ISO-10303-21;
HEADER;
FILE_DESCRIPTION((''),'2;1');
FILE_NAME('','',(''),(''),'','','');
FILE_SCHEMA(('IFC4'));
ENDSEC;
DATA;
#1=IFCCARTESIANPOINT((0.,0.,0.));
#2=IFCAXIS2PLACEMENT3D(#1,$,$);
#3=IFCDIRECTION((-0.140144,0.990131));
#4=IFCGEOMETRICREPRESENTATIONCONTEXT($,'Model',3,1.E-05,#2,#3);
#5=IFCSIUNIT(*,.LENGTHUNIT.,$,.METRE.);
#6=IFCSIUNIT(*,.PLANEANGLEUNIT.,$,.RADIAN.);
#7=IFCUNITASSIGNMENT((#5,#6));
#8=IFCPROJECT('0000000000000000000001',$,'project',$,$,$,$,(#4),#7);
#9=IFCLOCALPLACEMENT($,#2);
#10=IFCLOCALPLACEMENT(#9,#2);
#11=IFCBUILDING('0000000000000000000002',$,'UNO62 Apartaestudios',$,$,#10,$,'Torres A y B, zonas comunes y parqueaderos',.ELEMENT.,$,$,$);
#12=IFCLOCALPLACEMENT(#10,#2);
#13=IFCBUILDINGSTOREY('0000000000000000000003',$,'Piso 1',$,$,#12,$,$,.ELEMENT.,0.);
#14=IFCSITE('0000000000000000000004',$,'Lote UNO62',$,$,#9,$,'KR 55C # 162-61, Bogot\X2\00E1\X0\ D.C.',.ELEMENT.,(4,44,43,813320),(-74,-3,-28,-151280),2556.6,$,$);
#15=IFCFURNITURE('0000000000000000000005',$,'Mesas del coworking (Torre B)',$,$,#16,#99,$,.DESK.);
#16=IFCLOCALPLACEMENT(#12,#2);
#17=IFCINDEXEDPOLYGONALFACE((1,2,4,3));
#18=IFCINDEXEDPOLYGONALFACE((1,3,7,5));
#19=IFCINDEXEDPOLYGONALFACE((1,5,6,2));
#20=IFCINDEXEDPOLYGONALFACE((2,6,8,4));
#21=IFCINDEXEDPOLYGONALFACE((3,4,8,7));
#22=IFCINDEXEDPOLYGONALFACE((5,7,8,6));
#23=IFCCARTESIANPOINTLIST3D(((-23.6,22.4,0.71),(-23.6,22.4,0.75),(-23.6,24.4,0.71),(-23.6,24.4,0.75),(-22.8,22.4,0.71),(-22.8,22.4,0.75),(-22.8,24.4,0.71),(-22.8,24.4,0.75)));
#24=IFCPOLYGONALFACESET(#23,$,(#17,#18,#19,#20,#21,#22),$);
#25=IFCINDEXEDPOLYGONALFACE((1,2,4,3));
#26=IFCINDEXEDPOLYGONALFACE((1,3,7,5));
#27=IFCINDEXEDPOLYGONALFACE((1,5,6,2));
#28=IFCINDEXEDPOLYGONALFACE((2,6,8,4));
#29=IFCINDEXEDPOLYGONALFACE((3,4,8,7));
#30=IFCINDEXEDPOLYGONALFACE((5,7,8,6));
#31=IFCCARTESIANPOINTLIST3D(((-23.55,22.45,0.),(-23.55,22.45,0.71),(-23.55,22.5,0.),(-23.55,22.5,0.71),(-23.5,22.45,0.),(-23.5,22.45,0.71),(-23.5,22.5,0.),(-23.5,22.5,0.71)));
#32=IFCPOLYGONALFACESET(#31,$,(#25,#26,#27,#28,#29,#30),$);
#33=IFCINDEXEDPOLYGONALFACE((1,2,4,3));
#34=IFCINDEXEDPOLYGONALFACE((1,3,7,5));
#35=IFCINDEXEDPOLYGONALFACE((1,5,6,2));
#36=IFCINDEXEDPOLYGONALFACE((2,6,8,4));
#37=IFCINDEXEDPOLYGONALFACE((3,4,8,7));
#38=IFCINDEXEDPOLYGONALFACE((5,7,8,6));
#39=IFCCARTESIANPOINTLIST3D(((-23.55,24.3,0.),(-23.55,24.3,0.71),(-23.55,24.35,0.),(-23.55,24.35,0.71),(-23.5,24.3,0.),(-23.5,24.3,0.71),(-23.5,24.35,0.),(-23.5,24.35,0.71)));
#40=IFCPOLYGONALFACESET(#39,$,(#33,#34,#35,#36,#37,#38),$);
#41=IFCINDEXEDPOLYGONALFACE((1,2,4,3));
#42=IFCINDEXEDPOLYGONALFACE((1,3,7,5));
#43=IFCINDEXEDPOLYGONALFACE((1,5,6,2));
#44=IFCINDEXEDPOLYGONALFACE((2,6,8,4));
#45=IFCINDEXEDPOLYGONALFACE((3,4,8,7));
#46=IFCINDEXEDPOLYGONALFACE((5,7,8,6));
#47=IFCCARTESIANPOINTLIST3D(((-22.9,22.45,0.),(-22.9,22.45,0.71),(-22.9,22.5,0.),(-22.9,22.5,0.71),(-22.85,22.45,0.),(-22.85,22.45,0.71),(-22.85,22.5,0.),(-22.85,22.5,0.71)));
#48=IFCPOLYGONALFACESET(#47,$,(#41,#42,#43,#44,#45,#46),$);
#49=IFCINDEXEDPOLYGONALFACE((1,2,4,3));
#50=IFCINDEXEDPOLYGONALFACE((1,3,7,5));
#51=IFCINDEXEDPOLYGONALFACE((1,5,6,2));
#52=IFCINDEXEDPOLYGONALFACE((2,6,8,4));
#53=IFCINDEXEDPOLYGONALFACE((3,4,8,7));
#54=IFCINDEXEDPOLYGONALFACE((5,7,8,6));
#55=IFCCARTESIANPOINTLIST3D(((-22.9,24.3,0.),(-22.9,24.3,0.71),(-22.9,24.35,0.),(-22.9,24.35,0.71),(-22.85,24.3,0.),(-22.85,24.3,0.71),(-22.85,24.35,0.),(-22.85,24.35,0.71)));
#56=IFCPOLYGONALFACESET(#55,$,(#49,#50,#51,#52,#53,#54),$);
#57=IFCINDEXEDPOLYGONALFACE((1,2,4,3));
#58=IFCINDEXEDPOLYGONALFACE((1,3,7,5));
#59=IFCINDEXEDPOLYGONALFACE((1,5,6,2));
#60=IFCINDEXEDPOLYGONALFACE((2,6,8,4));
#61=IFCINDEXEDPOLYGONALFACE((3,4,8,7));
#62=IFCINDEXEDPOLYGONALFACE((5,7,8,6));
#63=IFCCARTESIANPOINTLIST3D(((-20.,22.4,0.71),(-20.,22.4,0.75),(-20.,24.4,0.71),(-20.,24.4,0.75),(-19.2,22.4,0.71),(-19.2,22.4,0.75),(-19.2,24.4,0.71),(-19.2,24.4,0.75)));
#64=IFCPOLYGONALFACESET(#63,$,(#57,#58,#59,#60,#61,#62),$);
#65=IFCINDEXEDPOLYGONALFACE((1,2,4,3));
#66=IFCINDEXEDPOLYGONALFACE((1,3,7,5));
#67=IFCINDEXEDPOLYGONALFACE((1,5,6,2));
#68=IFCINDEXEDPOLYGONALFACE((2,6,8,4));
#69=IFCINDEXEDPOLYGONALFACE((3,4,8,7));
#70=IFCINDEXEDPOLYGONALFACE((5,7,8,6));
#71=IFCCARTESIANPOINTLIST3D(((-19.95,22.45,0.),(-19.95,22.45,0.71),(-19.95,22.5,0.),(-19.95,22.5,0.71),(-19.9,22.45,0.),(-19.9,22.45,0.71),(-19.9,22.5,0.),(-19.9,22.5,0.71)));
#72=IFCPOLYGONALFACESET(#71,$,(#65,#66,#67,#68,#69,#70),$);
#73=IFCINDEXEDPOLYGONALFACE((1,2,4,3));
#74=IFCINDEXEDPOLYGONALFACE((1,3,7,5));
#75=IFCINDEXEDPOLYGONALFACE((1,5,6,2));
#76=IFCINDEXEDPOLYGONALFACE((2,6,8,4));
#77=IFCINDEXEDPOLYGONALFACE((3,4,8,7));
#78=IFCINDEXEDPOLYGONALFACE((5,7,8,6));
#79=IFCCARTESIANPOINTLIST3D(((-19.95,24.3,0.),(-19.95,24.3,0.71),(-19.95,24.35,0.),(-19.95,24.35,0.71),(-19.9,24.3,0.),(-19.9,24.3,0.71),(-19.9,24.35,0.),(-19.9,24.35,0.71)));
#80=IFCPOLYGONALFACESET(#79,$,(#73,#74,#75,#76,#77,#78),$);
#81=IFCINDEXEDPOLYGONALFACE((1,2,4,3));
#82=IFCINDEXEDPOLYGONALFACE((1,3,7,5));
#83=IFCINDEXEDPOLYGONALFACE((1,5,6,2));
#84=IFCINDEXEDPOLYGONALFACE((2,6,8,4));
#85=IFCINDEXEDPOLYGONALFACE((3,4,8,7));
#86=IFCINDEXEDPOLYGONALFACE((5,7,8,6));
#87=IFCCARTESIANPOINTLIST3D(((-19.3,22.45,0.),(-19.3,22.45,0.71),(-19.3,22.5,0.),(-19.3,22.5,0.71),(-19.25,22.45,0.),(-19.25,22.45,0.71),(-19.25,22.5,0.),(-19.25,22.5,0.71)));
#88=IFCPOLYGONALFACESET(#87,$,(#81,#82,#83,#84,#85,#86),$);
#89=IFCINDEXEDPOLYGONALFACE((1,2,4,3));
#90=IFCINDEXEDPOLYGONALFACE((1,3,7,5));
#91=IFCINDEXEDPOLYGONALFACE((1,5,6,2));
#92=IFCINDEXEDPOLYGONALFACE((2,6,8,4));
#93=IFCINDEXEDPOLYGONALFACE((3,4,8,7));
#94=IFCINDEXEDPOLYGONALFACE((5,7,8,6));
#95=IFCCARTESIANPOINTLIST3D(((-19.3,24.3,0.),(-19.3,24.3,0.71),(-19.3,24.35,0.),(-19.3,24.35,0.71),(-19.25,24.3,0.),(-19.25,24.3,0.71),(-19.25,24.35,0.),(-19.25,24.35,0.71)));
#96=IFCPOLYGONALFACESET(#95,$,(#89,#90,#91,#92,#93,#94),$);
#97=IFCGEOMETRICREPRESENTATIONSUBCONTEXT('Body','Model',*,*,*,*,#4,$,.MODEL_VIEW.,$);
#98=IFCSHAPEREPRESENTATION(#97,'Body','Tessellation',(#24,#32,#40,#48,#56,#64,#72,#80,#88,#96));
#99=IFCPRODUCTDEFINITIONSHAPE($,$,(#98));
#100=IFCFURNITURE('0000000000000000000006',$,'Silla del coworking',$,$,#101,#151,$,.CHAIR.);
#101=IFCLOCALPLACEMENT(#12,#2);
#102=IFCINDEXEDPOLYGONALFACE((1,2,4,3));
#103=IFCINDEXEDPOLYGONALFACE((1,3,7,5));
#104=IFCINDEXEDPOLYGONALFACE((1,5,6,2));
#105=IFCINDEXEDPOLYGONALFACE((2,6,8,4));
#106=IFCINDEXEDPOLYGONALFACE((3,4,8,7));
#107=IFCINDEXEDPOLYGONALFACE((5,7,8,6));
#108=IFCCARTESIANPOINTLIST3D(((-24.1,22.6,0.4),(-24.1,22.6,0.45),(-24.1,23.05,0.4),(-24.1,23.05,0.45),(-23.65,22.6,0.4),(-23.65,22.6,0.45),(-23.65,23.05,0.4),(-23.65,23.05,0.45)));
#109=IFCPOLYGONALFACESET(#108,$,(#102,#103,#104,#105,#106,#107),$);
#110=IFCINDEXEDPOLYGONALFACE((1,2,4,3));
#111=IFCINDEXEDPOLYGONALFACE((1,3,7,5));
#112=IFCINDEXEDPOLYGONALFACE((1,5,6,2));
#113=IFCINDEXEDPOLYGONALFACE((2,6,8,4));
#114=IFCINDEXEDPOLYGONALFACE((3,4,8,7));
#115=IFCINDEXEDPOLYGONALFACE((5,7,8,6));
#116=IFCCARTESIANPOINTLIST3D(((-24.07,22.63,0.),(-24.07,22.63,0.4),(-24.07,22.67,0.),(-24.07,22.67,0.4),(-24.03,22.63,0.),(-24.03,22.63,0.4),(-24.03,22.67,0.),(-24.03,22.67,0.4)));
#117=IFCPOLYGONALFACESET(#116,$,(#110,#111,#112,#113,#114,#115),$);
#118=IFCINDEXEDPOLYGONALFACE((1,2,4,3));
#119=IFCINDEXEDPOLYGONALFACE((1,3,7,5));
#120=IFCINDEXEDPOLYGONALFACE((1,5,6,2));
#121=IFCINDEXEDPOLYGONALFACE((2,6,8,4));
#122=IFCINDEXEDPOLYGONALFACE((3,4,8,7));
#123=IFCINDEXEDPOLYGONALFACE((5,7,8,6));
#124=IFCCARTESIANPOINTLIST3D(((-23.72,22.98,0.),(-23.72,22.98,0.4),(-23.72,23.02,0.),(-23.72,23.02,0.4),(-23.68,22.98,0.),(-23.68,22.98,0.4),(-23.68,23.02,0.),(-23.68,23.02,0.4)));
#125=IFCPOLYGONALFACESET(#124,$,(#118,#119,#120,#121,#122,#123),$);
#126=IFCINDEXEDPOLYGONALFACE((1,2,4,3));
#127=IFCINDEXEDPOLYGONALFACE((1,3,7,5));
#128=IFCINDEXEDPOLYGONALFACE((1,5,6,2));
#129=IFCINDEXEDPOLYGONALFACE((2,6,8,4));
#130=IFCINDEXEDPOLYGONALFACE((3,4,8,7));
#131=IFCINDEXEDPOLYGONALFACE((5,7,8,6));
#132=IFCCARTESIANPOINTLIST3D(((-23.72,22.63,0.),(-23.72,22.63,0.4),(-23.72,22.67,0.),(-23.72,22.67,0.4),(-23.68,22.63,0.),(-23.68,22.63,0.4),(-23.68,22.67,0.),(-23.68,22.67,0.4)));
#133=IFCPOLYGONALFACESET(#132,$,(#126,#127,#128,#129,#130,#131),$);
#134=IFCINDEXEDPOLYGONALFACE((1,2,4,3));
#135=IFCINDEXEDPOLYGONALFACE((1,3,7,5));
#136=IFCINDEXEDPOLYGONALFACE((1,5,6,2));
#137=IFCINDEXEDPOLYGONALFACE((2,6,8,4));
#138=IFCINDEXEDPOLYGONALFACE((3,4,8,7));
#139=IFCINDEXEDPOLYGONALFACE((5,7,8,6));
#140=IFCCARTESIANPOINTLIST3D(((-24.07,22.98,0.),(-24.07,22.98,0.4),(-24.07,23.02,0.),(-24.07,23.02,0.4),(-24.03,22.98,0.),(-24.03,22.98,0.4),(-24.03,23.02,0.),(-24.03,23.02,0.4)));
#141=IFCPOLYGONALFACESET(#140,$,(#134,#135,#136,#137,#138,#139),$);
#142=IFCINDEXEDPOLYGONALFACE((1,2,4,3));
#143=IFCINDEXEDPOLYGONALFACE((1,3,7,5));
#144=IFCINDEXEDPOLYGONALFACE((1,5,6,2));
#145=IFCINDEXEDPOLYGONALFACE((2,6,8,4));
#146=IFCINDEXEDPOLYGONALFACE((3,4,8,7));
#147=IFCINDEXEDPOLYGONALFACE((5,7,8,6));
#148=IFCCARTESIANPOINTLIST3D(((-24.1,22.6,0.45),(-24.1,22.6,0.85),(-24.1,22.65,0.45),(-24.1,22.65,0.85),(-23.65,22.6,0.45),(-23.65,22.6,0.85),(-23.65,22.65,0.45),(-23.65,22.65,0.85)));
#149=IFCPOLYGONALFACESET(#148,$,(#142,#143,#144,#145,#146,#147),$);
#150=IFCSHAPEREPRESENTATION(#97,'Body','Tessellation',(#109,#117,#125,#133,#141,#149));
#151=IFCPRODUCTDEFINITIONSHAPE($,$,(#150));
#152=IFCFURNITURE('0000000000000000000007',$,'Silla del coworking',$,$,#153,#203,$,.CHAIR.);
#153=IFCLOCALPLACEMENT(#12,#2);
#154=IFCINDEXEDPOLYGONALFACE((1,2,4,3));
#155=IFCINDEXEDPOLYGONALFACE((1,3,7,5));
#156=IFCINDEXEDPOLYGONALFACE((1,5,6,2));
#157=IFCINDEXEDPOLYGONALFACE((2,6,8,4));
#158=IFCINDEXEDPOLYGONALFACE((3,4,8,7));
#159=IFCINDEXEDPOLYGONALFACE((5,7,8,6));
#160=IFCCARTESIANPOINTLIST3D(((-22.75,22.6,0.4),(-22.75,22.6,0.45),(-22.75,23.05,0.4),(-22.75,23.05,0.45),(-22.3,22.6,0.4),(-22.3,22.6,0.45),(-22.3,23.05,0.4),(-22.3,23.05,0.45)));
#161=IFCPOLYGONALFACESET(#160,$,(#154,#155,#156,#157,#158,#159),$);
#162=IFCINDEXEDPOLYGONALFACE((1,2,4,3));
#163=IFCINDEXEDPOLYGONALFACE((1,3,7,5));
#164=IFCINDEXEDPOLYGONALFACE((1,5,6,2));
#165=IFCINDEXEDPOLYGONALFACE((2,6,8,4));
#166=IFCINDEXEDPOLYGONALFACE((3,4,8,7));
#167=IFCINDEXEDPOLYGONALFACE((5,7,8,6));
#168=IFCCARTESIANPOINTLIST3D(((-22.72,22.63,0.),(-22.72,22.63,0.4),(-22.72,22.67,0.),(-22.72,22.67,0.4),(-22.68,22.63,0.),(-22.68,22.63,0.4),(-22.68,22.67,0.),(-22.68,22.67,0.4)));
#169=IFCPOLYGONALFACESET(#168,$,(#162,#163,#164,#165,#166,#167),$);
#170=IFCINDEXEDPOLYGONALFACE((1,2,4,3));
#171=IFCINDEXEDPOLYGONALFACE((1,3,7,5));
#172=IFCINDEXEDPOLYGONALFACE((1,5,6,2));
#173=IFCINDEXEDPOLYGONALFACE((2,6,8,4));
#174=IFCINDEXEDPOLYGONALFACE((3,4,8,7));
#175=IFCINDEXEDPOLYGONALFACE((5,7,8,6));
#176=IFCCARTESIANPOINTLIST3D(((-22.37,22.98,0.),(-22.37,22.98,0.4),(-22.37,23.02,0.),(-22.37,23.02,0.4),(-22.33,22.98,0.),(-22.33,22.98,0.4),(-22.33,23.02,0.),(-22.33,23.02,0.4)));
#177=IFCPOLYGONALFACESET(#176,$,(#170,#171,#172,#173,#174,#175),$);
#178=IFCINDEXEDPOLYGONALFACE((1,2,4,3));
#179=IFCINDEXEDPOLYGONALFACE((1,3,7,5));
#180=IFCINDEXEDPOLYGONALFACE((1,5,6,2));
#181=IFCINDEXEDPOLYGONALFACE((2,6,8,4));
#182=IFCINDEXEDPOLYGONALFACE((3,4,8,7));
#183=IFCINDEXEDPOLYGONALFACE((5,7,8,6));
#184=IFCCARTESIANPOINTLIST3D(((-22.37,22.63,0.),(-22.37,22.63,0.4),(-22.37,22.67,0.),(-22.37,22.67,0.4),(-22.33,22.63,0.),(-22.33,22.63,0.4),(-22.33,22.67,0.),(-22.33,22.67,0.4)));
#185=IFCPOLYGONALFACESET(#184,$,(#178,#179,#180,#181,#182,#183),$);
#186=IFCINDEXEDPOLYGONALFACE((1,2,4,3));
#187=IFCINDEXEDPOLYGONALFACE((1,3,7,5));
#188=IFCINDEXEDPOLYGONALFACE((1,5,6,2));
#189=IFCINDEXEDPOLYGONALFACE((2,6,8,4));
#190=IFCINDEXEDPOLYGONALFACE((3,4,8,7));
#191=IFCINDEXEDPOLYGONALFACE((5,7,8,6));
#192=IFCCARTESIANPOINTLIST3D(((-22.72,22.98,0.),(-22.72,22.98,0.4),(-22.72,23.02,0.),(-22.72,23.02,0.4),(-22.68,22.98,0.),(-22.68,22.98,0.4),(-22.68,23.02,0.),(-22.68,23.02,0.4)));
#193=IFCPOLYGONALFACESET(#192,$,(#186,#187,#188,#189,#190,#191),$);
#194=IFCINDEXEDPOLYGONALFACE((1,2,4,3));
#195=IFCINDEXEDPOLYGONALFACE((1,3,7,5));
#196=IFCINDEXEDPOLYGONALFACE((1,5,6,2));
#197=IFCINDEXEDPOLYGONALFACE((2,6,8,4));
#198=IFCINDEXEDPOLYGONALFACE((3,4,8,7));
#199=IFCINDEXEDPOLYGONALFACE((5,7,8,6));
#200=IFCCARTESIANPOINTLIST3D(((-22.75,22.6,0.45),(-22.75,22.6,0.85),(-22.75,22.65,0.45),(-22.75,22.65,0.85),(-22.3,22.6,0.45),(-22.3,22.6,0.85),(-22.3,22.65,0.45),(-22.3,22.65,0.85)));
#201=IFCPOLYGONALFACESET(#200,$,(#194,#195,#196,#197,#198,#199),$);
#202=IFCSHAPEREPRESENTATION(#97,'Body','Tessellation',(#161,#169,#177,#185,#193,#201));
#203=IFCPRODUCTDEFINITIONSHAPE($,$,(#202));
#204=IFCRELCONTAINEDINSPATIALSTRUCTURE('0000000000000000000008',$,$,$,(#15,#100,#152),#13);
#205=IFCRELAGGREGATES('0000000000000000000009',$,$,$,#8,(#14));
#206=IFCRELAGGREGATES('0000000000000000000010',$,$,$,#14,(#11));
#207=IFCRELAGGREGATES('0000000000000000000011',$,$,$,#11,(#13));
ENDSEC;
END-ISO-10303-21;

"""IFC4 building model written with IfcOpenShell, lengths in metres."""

from ifc_helpers import new_model, si_unit, direction, frame, frame_2d, origin, place, context, subcontext, project, spatial, rectangle, extrude, element, save


model = new_model("IFC4")

# Units and contexts
model_context = context("Model", 3, precision=1e-05, world=origin(), true_north=direction((-0.140144, 0.990131)))
body_context = subcontext(model_context, "Body", "Model", "MODEL_VIEW")
ifc_project = project(units=[si_unit("LENGTHUNIT", "METRE"), si_unit("PLANEANGLEUNIT", "RADIAN")], contexts=[model_context])

# Site, building, storey
site_placement = place(None, origin())
site = spatial("IfcSite", under=ifc_project, at=site_placement, Name="Lote UNO62", LongName="KR 55C # 162-61, Bogotá D.C.", CompositionType="ELEMENT", RefLatitude=(4, 44, 43, 813320), RefLongitude=(-74, -3, -28, -151280), RefElevation=2556.6)
building_placement = place(site_placement, origin())
building = spatial("IfcBuilding", under=site, at=building_placement, Name="UNO62 Apartaestudios", LongName="Torres A y B, zonas comunes y parqueaderos", CompositionType="ELEMENT")
storey_placement = place(building_placement, origin())
storey = spatial("IfcBuildingStorey", under=building, at=storey_placement, Name="Piso 1", CompositionType="ELEMENT", Elevation=0.0)

# Furniture
furniture_1_placement = place(storey_placement, origin())
element("IfcFurniture", 1, at=furniture_1_placement, inside=storey, Name="Mesas del coworking (Torre B)", PredefinedType="DESK", context=body_context, shape_type="SweptSolid", body=[
    extrude(rectangle(XDim=0.8, YDim=2.0, at=frame_2d((-23.2, 23.4))), frame((0.0, 0.0, 0.71)), (0.0, 0.0, 1.0), 0.04),
    extrude(rectangle(XDim=0.05, YDim=0.05, at=frame_2d((-23.525, 22.475))), origin(), (0.0, 0.0, 1.0), 0.71),
    extrude(rectangle(XDim=0.05, YDim=0.05, at=frame_2d((-23.525, 24.325))), origin(), (0.0, 0.0, 1.0), 0.71),
    extrude(rectangle(XDim=0.05, YDim=0.05, at=frame_2d((-22.875, 22.475))), origin(), (0.0, 0.0, 1.0), 0.71),
    extrude(rectangle(XDim=0.05, YDim=0.05, at=frame_2d((-22.875, 24.325))), origin(), (0.0, 0.0, 1.0), 0.71),
    extrude(rectangle(XDim=0.8, YDim=2.0, at=frame_2d((-19.6, 23.4))), frame((0.0, 0.0, 0.71)), (0.0, 0.0, 1.0), 0.04),
    extrude(rectangle(XDim=0.05, YDim=0.05, at=frame_2d((-19.925, 22.475))), origin(), (0.0, 0.0, 1.0), 0.71),
    extrude(rectangle(XDim=0.05, YDim=0.05, at=frame_2d((-19.925, 24.325))), origin(), (0.0, 0.0, 1.0), 0.71),
    extrude(rectangle(XDim=0.05, YDim=0.05, at=frame_2d((-19.275, 22.475))), origin(), (0.0, 0.0, 1.0), 0.71),
    extrude(rectangle(XDim=0.05, YDim=0.05, at=frame_2d((-19.275, 24.325))), origin(), (0.0, 0.0, 1.0), 0.71),
])
furniture_2_placement = place(storey_placement, origin())
element("IfcFurniture", 2, at=furniture_2_placement, inside=storey, Name="Silla del coworking", PredefinedType="CHAIR", context=body_context, shape_type="SweptSolid", body=[
    extrude(rectangle(XDim=0.45, YDim=0.45, at=frame_2d((-23.875, 22.825))), frame((0.0, 0.0, 0.4)), (0.0, 0.0, 1.0), 0.05),
    extrude(rectangle(XDim=0.04, YDim=0.04, at=frame_2d((-24.05, 22.65))), origin(), (0.0, 0.0, 1.0), 0.4),
    extrude(rectangle(XDim=0.04, YDim=0.04, at=frame_2d((-23.7, 23.0))), origin(), (0.0, 0.0, 1.0), 0.4),
    extrude(rectangle(XDim=0.04, YDim=0.04, at=frame_2d((-23.7, 22.65))), origin(), (0.0, 0.0, 1.0), 0.4),
    extrude(rectangle(XDim=0.04, YDim=0.04, at=frame_2d((-24.05, 23.0))), origin(), (0.0, 0.0, 1.0), 0.4),
    extrude(rectangle(XDim=0.45, YDim=0.05, at=frame_2d((-23.875, 22.625))), frame((0.0, 0.0, 0.45)), (0.0, 0.0, 1.0), 0.4),
])
furniture_3_placement = place(storey_placement, origin())
element("IfcFurniture", 3, at=furniture_3_placement, inside=storey, Name="Silla del coworking", PredefinedType="CHAIR", context=body_context, shape_type="SweptSolid", body=[
    extrude(rectangle(XDim=0.45, YDim=0.45, at=frame_2d((-22.525, 22.825))), frame((0.0, 0.0, 0.4)), (0.0, 0.0, 1.0), 0.05),
    extrude(rectangle(XDim=0.04, YDim=0.04, at=frame_2d((-22.7, 22.65))), origin(), (0.0, 0.0, 1.0), 0.4),
    extrude(rectangle(XDim=0.04, YDim=0.04, at=frame_2d((-22.35, 23.0))), origin(), (0.0, 0.0, 1.0), 0.4),
    extrude(rectangle(XDim=0.04, YDim=0.04, at=frame_2d((-22.35, 22.65))), origin(), (0.0, 0.0, 1.0), 0.4),
    extrude(rectangle(XDim=0.04, YDim=0.04, at=frame_2d((-22.7, 23.0))), origin(), (0.0, 0.0, 1.0), 0.4),
    extrude(rectangle(XDim=0.45, YDim=0.05, at=frame_2d((-22.525, 22.625))), frame((0.0, 0.0, 0.45)), (0.0, 0.0, 1.0), 0.4),
])

save(model, "model.ifc")
